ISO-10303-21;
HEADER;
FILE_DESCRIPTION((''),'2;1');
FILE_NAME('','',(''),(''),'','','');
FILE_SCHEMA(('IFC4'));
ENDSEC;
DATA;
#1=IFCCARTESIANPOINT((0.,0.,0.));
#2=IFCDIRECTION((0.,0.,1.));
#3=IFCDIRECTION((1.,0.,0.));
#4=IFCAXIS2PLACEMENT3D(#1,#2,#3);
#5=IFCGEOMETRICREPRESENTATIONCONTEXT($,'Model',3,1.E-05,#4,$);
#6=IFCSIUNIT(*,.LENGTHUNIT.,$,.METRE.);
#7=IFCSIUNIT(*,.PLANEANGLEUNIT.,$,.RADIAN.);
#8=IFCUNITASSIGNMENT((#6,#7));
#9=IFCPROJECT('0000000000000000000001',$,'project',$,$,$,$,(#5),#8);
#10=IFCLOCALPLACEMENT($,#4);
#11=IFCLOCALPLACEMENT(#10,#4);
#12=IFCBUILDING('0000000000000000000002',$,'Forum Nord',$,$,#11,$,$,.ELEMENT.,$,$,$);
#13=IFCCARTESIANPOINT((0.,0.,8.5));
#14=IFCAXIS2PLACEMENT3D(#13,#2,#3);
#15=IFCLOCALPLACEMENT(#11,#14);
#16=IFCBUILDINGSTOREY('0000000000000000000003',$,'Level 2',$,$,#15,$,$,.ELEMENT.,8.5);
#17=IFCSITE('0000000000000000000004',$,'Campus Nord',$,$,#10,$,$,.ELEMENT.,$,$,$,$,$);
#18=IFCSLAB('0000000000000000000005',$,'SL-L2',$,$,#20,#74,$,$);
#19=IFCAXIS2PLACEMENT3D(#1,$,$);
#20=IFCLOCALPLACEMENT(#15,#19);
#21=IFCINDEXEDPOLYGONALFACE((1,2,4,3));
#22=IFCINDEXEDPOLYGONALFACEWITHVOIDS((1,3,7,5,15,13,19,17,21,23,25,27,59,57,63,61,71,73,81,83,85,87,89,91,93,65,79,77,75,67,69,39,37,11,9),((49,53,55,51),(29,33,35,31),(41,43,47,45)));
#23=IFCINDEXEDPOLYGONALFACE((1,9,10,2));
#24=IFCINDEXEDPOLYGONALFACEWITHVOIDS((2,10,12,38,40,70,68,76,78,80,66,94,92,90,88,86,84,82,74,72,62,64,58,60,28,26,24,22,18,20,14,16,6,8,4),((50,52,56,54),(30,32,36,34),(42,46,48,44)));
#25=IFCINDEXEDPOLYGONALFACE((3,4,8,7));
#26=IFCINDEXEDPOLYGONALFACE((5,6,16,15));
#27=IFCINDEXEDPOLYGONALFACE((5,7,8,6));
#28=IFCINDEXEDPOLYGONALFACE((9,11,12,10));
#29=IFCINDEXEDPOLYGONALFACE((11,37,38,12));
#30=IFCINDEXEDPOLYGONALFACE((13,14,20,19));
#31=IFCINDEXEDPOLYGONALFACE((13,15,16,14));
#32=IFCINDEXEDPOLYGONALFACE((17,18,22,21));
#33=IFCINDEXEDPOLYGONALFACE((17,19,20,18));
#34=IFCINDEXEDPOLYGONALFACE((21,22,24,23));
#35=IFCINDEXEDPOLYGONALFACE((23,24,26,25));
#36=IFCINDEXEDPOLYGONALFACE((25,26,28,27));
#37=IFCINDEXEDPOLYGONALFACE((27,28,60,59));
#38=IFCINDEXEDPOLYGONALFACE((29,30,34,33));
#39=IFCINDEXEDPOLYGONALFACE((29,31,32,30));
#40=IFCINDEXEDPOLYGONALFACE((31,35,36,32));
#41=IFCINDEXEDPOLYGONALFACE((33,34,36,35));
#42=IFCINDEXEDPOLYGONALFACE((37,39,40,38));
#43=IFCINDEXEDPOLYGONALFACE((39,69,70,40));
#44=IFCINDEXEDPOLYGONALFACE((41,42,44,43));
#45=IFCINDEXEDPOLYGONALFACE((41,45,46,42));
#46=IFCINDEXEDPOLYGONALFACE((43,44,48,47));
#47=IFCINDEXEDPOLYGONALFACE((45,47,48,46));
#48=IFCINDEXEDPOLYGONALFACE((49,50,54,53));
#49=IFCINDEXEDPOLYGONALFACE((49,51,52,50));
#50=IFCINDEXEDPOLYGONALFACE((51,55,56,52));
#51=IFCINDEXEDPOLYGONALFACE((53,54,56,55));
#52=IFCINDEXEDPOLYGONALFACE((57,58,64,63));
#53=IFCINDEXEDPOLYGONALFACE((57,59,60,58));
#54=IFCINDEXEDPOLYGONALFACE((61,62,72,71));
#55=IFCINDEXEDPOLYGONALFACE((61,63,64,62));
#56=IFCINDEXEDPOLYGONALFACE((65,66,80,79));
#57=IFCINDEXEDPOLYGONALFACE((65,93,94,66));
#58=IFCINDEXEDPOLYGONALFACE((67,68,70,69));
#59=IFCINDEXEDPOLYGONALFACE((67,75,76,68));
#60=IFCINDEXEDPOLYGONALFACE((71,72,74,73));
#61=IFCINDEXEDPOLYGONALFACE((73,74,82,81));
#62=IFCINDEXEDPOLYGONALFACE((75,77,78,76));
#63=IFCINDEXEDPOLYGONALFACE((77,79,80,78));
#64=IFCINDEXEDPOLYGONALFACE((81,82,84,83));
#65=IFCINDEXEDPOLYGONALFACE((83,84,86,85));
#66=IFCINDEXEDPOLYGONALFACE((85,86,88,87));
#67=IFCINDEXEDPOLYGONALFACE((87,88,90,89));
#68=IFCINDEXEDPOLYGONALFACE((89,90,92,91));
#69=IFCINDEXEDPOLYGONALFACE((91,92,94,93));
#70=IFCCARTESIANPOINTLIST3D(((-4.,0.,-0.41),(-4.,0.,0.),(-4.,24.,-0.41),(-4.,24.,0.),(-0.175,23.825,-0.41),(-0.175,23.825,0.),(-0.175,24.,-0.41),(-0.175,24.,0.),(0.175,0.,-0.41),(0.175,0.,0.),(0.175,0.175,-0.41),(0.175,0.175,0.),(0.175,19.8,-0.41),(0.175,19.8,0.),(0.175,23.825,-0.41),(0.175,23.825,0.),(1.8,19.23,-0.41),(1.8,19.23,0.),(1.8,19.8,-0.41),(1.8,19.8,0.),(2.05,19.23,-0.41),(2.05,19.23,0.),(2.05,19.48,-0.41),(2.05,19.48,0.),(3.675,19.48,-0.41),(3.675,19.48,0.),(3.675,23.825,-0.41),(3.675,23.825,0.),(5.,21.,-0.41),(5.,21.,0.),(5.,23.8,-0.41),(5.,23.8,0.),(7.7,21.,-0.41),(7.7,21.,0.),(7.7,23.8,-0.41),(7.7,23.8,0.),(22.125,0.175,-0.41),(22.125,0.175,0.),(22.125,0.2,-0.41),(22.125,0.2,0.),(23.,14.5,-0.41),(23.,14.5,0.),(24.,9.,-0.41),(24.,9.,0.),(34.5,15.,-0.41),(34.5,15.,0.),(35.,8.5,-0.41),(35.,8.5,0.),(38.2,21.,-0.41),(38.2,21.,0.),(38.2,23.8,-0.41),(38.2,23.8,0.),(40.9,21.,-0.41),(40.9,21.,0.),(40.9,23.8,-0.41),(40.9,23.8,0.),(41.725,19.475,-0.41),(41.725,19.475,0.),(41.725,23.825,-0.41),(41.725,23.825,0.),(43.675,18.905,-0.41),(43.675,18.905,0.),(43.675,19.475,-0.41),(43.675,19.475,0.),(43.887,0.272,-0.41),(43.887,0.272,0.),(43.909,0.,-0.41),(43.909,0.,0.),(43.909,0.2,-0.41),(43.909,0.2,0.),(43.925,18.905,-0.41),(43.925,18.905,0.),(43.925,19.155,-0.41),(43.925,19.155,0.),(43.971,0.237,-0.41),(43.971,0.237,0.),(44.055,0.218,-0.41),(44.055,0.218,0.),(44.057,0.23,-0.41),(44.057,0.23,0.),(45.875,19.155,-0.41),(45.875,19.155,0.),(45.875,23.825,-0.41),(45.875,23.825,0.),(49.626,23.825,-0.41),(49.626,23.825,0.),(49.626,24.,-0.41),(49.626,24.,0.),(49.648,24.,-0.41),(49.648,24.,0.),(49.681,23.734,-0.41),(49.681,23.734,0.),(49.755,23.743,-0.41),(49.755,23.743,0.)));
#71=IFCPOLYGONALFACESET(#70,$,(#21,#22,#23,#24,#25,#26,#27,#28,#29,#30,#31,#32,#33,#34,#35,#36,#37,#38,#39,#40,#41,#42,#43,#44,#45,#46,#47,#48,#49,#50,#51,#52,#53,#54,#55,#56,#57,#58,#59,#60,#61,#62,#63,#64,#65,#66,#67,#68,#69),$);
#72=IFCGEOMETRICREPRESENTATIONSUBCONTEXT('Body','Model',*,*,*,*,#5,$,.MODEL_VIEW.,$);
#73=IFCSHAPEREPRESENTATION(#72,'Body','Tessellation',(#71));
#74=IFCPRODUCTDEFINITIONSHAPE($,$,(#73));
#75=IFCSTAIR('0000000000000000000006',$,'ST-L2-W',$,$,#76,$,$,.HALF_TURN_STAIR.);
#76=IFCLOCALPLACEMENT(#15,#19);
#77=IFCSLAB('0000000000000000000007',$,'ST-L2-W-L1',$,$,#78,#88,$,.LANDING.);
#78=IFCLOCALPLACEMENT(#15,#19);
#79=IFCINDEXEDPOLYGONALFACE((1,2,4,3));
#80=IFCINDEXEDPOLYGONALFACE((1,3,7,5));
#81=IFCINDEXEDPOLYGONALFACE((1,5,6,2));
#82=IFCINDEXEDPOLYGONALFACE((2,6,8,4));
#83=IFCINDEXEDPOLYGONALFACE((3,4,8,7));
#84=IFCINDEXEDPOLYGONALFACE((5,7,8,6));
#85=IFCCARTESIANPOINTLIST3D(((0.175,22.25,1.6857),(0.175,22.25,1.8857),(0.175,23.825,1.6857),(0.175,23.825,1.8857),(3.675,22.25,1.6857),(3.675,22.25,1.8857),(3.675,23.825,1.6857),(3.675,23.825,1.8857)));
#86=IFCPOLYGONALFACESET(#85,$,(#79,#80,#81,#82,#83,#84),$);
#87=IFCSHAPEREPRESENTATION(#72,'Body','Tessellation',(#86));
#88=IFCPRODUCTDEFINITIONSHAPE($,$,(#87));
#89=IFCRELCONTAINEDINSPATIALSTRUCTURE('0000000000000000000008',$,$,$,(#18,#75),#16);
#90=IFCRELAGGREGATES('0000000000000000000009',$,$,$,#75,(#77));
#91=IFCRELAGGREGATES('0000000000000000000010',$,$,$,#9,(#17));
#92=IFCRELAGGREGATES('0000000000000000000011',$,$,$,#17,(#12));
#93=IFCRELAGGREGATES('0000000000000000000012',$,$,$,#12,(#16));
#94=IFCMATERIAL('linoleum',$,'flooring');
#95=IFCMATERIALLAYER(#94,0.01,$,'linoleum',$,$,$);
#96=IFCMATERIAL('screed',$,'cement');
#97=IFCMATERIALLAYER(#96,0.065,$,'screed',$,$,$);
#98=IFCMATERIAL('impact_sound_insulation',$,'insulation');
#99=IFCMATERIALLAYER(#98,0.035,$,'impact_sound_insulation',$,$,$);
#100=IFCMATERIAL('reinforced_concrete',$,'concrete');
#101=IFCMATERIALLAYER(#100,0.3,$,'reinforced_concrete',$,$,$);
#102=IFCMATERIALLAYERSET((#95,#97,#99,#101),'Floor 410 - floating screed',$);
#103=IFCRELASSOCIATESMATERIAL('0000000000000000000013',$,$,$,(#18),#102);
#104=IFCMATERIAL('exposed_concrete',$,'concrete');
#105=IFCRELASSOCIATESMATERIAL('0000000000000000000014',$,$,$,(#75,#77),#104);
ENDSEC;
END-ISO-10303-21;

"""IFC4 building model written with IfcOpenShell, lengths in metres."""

from ifc_helpers import new_model, si_unit, frame, origin_with_axes, place, context, subcontext, project, spatial, polyline, outline, extrude, material, layer, layer_set, layer_usage, element, aggregate, save


model = new_model("IFC4")

# Units and contexts
model_context = context("Model", 3, precision=1e-05, world=origin_with_axes())
body_context = subcontext(model_context, "Body", "Model", "MODEL_VIEW")
ifc_project = project(units=[si_unit("LENGTHUNIT", "METRE"), si_unit("PLANEANGLEUNIT", "RADIAN")], contexts=[model_context])

# Site, building, storey
site_placement = place(None, origin_with_axes())
site = spatial("IfcSite", under=ifc_project, at=site_placement, Name="Campus Nord", CompositionType="ELEMENT")
building_placement = place(site_placement, origin_with_axes())
building = spatial("IfcBuilding", under=site, at=building_placement, Name="Forum Nord", CompositionType="ELEMENT")
storey_placement = place(building_placement, frame((0.0, 0.0, 8.5), z_axis=(0.0, 0.0, 1.0), x_axis=(1.0, 0.0, 0.0)))
storey = spatial("IfcBuildingStorey", under=building, at=storey_placement, Name="Level 2", CompositionType="ELEMENT", Elevation=8.5)

# Slab
ifc_material_1 = material(Name="linoleum", Category="flooring")
ifc_layer_1 = layer(ifc_material_1, 0.01, Name="linoleum")
ifc_material_2 = material(Name="screed", Category="cement")
ifc_layer_2 = layer(ifc_material_2, 0.065, Name="screed")
ifc_material_3 = material(Name="impact_sound_insulation", Category="insulation")
ifc_layer_3 = layer(ifc_material_3, 0.035, Name="impact_sound_insulation")
ifc_material_4 = material(Name="reinforced_concrete", Category="concrete")
ifc_layer_4 = layer(ifc_material_4, 0.3, Name="reinforced_concrete")
ifc_layer_set = layer_set([ifc_layer_1, ifc_layer_2, ifc_layer_3, ifc_layer_4], Name="Floor 410 - floating screed")
ifc_layer_usage = layer_usage(ifc_layer_set, "AXIS3", "NEGATIVE", 0.0)
slab_1_placement = place(storey_placement, origin_with_axes())
element("IfcSlab", 1, at=slab_1_placement, inside=storey, material=ifc_layer_usage, Name="SL-L2", context=body_context, shape_type="SweptSolid", body=[
    extrude(outline(polyline([(49.648, 24.0), (49.626, 24.0), (49.626, 23.825), (45.875, 23.825), (45.875, 19.155), (43.925, 19.155), (43.925, 18.905), (43.675, 18.905), (43.675, 19.475), (41.725, 19.475), (41.725, 23.825), (3.675, 23.825), (3.675, 19.48), (2.05, 19.48), (2.05, 19.23), (1.8, 19.23), (1.8, 19.8), (0.175, 19.8), (0.175, 23.825), (-0.175, 23.825), (-0.175, 24.0), (-4.0, 24.0), (-4.0, 0.0), (0.175, 0.0), (0.175, 0.175), (22.125, 0.175), (22.125, 0.2), (43.909, 0.2), (43.909, 0.0), (43.971, 0.237), (44.055, 0.218), (44.057, 0.23), (43.887, 0.272), (49.755, 23.743), (49.681, 23.734), (49.648, 24.0)]), holes=[polyline([(38.2, 23.8), (40.9, 23.8), (40.9, 21.0), (38.2, 21.0), (38.2, 23.8)]), polyline([(23.0, 14.5), (34.5, 15.0), (35.0, 8.5), (24.0, 9.0), (23.0, 14.5)]), polyline([(5.0, 23.8), (7.7, 23.8), (7.7, 21.0), (5.0, 21.0), (5.0, 23.8)])]), frame((0.0, 0.0, -0.41), z_axis=(0.0, 0.0, 1.0), x_axis=(1.0, 0.0, 0.0)), (0.0, 0.0, 1.0), 0.41),
])

# Stair, slab
ifc_material_5 = material(Name="exposed_concrete", Category="concrete")
stair_placement = place(storey_placement, origin_with_axes())
stair = element("IfcStair", 2, at=stair_placement, inside=storey, material=ifc_material_5, Name="ST-L2-W", PredefinedType="HALF_TURN_STAIR")
slab_2_placement = place(storey_placement, frame((0.0, 0.0, 1.8857), z_axis=(0.0, 0.0, 1.0), x_axis=(1.0, 0.0, 0.0)))
slab_2 = element("IfcSlab", 3, at=slab_2_placement, material=ifc_material_5, Name="ST-L2-W-L1", PredefinedType="LANDING", context=body_context, shape_type="SweptSolid", body=[
    extrude(outline(polyline([(0.175, 22.25), (3.675, 22.25), (3.675, 23.825), (0.175, 23.825), (0.175, 22.25)])), frame((0.0, 0.0, -0.2), z_axis=(0.0, 0.0, 1.0), x_axis=(1.0, 0.0, 0.0)), (0.0, 0.0, 1.0), 0.2),
])
aggregate(stair, [slab_2])

save(model, "model.ifc")
